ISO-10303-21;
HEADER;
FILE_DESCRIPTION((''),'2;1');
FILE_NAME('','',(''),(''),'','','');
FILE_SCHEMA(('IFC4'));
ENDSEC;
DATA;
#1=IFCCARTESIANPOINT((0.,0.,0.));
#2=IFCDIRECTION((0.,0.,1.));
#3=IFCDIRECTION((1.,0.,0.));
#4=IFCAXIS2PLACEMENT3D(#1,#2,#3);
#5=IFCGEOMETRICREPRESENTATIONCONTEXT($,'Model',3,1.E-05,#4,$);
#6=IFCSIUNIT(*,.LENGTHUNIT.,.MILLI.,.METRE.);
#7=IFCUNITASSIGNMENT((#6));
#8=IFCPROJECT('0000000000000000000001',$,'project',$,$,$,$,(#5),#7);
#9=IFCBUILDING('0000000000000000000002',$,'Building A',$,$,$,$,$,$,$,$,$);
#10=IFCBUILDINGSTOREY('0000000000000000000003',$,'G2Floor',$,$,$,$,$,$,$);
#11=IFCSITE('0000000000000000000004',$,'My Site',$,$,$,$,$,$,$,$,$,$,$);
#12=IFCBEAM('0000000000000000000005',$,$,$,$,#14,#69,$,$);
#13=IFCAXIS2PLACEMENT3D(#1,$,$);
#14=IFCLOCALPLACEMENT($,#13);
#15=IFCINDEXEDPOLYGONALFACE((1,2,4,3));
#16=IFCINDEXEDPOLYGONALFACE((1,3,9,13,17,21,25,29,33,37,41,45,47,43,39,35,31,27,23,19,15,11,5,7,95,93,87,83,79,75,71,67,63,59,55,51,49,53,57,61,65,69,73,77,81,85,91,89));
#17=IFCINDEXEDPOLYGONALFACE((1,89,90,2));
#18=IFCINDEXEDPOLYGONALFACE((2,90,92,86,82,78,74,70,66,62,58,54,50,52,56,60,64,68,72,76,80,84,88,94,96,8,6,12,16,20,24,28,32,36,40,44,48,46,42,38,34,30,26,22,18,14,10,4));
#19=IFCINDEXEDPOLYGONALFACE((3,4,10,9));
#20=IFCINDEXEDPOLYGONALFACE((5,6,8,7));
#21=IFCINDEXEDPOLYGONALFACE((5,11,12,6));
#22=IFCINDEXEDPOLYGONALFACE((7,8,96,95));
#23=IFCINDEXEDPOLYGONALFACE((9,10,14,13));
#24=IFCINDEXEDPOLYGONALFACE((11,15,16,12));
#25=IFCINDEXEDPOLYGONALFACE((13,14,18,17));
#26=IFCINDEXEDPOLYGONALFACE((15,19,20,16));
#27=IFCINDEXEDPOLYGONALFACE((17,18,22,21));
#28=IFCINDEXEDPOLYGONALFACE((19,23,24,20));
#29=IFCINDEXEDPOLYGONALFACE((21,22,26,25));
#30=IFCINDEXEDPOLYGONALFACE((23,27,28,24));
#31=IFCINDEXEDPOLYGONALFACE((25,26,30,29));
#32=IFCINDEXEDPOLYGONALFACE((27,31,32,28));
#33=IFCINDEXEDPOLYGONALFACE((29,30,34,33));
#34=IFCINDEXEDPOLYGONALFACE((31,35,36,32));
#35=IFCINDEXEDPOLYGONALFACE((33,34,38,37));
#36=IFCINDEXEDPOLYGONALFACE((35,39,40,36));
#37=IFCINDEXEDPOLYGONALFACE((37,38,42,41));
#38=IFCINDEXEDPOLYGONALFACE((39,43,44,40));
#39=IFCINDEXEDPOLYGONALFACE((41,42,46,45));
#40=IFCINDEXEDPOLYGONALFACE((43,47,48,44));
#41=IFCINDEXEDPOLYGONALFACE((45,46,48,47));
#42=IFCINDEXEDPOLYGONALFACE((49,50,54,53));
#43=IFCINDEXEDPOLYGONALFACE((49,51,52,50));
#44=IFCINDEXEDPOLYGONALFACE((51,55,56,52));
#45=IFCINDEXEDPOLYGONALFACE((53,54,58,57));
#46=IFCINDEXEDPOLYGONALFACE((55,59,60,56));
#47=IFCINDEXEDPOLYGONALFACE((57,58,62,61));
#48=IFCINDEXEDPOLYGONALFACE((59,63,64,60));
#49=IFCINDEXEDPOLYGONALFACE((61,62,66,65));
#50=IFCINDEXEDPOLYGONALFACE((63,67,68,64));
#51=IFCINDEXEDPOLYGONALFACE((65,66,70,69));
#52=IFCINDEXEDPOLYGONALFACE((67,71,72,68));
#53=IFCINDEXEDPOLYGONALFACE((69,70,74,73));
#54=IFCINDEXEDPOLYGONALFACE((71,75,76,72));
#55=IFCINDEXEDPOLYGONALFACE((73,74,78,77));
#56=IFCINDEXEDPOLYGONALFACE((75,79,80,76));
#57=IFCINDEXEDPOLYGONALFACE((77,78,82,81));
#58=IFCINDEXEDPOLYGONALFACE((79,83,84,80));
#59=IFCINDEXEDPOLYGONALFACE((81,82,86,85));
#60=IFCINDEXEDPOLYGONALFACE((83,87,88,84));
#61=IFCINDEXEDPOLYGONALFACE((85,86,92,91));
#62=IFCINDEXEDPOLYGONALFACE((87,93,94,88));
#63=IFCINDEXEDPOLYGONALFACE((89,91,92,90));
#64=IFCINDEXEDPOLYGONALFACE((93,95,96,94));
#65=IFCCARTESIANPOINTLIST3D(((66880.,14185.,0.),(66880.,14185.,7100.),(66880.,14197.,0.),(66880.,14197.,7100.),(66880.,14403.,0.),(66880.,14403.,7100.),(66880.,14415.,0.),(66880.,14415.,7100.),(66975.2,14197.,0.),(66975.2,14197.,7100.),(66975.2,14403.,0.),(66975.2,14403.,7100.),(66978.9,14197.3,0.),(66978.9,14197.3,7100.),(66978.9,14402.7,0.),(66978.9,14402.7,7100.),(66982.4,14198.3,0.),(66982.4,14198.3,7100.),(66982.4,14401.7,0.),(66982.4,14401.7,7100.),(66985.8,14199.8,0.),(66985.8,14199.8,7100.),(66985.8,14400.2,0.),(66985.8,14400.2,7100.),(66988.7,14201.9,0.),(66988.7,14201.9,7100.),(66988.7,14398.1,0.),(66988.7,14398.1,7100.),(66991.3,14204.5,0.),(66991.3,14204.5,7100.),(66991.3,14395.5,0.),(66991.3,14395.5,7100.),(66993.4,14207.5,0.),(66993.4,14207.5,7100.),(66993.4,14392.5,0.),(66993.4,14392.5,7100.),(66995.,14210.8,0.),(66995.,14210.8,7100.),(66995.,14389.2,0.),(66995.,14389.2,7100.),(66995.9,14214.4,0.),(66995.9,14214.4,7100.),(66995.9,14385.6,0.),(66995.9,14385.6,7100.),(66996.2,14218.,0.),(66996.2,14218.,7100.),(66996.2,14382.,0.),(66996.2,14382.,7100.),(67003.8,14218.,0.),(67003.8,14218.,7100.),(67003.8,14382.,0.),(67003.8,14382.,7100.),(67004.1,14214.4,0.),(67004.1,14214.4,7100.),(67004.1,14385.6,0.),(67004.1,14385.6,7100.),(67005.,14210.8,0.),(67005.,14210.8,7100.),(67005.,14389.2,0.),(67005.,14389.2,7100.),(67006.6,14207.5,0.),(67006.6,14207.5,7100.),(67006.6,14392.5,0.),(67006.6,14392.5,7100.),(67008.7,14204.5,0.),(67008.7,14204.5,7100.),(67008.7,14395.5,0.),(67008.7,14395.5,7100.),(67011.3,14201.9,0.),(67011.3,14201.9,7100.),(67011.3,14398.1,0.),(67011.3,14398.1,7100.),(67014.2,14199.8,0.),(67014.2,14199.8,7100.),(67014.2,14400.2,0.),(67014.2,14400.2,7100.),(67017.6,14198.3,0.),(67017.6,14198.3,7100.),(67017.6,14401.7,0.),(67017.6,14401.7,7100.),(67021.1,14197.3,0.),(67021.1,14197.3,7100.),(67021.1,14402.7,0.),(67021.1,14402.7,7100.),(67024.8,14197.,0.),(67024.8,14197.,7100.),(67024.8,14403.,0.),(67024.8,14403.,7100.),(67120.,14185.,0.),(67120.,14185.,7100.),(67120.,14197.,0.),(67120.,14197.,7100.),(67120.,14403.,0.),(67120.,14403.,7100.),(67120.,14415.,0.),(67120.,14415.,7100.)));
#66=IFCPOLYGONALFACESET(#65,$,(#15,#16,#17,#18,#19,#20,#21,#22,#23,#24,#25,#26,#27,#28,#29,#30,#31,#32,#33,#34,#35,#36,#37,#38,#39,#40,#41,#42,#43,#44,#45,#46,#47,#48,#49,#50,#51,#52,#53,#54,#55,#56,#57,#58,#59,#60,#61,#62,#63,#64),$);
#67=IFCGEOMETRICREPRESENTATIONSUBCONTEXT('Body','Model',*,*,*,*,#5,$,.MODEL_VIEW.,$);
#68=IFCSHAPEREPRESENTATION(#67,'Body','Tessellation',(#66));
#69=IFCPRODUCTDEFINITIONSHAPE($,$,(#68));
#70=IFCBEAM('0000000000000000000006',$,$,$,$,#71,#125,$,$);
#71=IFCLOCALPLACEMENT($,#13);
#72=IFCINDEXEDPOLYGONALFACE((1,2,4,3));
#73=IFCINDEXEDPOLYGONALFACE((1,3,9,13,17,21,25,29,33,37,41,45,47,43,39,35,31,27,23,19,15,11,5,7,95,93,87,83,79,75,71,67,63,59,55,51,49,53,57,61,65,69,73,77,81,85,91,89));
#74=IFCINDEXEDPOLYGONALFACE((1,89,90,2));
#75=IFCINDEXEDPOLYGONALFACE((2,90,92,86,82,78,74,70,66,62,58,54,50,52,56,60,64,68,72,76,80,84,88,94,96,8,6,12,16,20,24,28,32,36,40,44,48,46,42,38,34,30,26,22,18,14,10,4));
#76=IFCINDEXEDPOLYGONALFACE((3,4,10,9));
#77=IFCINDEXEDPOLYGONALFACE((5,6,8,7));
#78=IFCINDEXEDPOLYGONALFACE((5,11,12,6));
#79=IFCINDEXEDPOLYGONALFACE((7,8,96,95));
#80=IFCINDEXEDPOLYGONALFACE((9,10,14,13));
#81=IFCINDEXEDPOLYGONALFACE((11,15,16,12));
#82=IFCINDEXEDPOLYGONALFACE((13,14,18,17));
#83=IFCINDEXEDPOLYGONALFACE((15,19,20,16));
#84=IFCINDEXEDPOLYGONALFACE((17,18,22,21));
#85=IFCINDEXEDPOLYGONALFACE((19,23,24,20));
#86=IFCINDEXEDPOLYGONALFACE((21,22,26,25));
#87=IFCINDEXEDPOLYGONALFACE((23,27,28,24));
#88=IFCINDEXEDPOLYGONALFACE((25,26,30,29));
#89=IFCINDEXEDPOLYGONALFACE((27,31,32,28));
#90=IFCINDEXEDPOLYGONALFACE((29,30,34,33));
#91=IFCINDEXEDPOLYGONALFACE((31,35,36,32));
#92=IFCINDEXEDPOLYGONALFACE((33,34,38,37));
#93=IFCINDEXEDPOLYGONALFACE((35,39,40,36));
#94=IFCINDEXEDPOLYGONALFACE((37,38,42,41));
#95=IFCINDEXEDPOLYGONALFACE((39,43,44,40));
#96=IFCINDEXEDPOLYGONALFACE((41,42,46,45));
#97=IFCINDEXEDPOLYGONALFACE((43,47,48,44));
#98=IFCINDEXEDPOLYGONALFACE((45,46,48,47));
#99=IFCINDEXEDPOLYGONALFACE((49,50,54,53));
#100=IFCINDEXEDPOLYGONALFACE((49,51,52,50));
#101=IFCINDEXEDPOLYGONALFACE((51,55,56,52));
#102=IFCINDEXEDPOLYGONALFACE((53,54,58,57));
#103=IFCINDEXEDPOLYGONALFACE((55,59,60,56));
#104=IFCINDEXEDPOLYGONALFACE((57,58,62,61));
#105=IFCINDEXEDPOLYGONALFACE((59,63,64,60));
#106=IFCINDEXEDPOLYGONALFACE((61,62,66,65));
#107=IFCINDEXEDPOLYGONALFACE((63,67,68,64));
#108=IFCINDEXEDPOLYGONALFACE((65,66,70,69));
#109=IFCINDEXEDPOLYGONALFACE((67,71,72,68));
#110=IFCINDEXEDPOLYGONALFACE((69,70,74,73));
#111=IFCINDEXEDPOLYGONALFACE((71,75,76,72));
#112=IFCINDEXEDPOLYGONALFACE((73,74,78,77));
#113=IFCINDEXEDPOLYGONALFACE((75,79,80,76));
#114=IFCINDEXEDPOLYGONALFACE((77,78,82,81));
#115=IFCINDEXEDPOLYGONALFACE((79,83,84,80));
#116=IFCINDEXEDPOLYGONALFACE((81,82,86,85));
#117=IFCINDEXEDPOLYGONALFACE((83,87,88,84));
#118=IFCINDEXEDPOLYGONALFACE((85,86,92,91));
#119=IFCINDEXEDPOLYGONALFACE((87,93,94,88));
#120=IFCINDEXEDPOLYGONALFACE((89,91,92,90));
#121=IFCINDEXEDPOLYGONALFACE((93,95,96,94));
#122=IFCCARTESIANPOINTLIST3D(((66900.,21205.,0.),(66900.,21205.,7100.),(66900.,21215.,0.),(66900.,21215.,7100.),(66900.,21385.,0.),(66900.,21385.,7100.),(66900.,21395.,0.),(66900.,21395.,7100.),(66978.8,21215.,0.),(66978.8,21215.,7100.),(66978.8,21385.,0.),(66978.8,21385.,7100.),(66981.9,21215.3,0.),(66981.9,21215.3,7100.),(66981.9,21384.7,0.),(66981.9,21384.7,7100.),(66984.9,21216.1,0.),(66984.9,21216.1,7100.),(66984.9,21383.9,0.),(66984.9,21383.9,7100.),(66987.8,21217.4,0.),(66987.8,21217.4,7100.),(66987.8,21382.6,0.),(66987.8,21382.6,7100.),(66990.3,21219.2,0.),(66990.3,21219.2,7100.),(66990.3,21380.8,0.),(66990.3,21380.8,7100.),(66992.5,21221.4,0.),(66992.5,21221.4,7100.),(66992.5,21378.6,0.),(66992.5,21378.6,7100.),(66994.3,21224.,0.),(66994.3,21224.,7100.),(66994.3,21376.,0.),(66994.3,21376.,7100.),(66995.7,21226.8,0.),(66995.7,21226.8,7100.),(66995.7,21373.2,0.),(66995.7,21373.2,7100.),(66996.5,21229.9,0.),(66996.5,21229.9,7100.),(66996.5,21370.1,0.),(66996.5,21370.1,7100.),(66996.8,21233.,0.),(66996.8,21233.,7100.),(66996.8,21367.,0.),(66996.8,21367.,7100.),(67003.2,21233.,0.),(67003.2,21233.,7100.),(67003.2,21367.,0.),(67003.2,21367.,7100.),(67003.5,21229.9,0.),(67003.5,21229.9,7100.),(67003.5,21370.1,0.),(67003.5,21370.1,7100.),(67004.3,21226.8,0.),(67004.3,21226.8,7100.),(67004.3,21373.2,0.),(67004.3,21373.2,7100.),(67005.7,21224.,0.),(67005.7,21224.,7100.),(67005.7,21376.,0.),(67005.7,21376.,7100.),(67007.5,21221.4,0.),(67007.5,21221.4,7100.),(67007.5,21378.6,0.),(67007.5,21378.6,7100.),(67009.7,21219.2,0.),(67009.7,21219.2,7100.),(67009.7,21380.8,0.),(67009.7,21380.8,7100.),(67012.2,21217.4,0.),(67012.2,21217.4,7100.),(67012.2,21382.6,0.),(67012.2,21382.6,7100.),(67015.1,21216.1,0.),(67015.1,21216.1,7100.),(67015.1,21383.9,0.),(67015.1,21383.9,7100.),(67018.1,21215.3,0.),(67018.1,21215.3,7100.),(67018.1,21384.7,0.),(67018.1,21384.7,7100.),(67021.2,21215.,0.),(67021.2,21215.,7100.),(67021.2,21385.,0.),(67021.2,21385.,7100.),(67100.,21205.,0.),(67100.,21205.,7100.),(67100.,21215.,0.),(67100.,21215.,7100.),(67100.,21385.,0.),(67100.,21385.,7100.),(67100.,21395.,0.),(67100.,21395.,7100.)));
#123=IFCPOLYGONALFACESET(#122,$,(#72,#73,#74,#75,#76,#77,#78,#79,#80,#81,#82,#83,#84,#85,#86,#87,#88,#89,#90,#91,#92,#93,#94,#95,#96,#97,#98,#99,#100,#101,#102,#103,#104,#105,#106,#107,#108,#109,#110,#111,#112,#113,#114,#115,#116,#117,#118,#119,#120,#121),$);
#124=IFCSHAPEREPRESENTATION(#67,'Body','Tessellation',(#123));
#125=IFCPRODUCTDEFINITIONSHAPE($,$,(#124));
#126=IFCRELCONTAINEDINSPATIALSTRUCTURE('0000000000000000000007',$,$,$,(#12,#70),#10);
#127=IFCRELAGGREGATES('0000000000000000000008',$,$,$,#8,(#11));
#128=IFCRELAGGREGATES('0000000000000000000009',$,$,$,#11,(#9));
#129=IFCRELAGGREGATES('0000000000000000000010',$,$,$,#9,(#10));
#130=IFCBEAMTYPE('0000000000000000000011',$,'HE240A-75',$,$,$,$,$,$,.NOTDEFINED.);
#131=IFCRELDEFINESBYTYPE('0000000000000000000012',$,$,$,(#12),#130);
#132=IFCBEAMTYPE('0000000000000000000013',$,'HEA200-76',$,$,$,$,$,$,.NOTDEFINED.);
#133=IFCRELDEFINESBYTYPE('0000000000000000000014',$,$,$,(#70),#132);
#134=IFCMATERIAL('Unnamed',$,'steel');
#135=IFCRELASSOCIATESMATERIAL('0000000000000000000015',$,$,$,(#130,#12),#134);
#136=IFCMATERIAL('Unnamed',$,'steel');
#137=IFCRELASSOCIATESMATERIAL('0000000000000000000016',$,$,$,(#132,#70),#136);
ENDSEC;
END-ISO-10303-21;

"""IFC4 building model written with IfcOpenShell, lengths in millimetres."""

from ifc_helpers import new_model, si_unit, frame, origin_with_axes, place, context, subcontext, project, spatial, polyline, outline, extrude, material, material_profile, profile_set, profile_usage, type_object, element, save


model = new_model("IFC4")

# Units and contexts
model_context = context("Model", 3, precision=1e-05, world=origin_with_axes())
body_context = subcontext(model_context, "Body", "Model", "MODEL_VIEW")
ifc_project = project(units=[si_unit("LENGTHUNIT", "METRE", prefix="MILLI")], contexts=[model_context])

# Site, building, storey
site = spatial("IfcSite", under=ifc_project, Name="My Site")
building = spatial("IfcBuilding", under=site, Name="Building A")
storey = spatial("IfcBuildingStorey", under=building, Name="G2Floor")

# Beams
ifc_material_1 = material(Name="Unnamed", Category="steel")
ifc_material_profile_1 = material_profile(ifc_material_1, outline(polyline([(120.0, -115.0), (120.0, -103.0), (120.0, -103.0), (24.8, -103.0), (24.8, -103.0), (21.1, -102.7), (21.1, -102.7), (17.6, -101.7), (17.6, -101.7), (14.2, -100.2), (14.2, -100.2), (11.3, -98.1), (11.3, -98.1), (8.7, -95.5), (8.7, -95.5), (6.6, -92.5), (6.6, -92.5), (5.0, -89.2), (5.0, -89.2), (4.1, -85.6), (4.1, -85.6), (3.8, -82.0), (3.8, -82.0), (3.8, 82.0), (3.8, 82.0), (4.1, 85.6), (4.1, 85.6), (5.0, 89.2), (5.0, 89.2), (6.6, 92.5), (6.6, 92.5), (8.7, 95.5), (8.7, 95.5), (11.3, 98.1), (11.3, 98.1), (14.2, 100.2), (14.2, 100.2), (17.6, 101.7), (17.6, 101.7), (21.1, 102.7), (21.1, 102.7), (24.8, 103.0), (24.8, 103.0), (120.0, 103.0), (120.0, 103.0), (120.0, 115.0), (120.0, 115.0), (-120.0, 115.0), (-120.0, 115.0), (-120.0, 103.0), (-120.0, 103.0), (-24.8, 103.0), (-24.8, 103.0), (-21.1, 102.7), (-21.1, 102.7), (-17.6, 101.7), (-17.6, 101.7), (-14.2, 100.2), (-14.2, 100.2), (-11.3, 98.1), (-11.3, 98.1), (-8.7, 95.5), (-8.7, 95.5), (-6.6, 92.5), (-6.6, 92.5), (-5.0, 89.2), (-5.0, 89.2), (-4.1, 85.6), (-4.1, 85.6), (-3.8, 82.0), (-3.8, 82.0), (-3.8, -82.0), (-3.8, -82.0), (-4.1, -85.6), (-4.1, -85.6), (-5.0, -89.2), (-5.0, -89.2), (-6.6, -92.5), (-6.6, -92.5), (-8.7, -95.5), (-8.7, -95.5), (-11.3, -98.1), (-11.3, -98.1), (-14.2, -100.2), (-14.2, -100.2), (-17.6, -101.7), (-17.6, -101.7), (-21.1, -102.7), (-21.1, -102.7), (-24.8, -103.0), (-24.8, -103.0), (-120.0, -103.0), (-120.0, -103.0), (-120.0, -115.0), (-120.0, -115.0), (120.0, -115.0)])))
ifc_profile_set_1 = profile_set([ifc_material_profile_1], Name="HE240A-75")
ifc_profile_usage_1 = profile_usage(ifc_profile_set_1)
beam_type_1 = type_object("IfcBeamType", Name="HE240A-75", PredefinedType="NOTDEFINED", material=ifc_profile_set_1)
beam_1_placement = place(None, frame((67000.0, 14300.0, 0.0), z_axis=(0.0, 0.0, 1.0), x_axis=(1.0, 0.0, 0.0)))
element("IfcBeam", 1, at=beam_1_placement, inside=storey, type_object=beam_type_1, material=ifc_profile_usage_1, context=body_context, shape_type="SweptSolid", body=[
    extrude(outline(polyline([(120.0, -115.0), (120.0, -103.0), (120.0, -103.0), (24.8, -103.0), (24.8, -103.0), (21.1, -102.7), (21.1, -102.7), (17.6, -101.7), (17.6, -101.7), (14.2, -100.2), (14.2, -100.2), (11.3, -98.1), (11.3, -98.1), (8.7, -95.5), (8.7, -95.5), (6.6, -92.5), (6.6, -92.5), (5.0, -89.2), (5.0, -89.2), (4.1, -85.6), (4.1, -85.6), (3.8, -82.0), (3.8, -82.0), (3.8, 82.0), (3.8, 82.0), (4.1, 85.6), (4.1, 85.6), (5.0, 89.2), (5.0, 89.2), (6.6, 92.5), (6.6, 92.5), (8.7, 95.5), (8.7, 95.5), (11.3, 98.1), (11.3, 98.1), (14.2, 100.2), (14.2, 100.2), (17.6, 101.7), (17.6, 101.7), (21.1, 102.7), (21.1, 102.7), (24.8, 103.0), (24.8, 103.0), (120.0, 103.0), (120.0, 103.0), (120.0, 115.0), (120.0, 115.0), (-120.0, 115.0), (-120.0, 115.0), (-120.0, 103.0), (-120.0, 103.0), (-24.8, 103.0), (-24.8, 103.0), (-21.1, 102.7), (-21.1, 102.7), (-17.6, 101.7), (-17.6, 101.7), (-14.2, 100.2), (-14.2, 100.2), (-11.3, 98.1), (-11.3, 98.1), (-8.7, 95.5), (-8.7, 95.5), (-6.6, 92.5), (-6.6, 92.5), (-5.0, 89.2), (-5.0, 89.2), (-4.1, 85.6), (-4.1, 85.6), (-3.8, 82.0), (-3.8, 82.0), (-3.8, -82.0), (-3.8, -82.0), (-4.1, -85.6), (-4.1, -85.6), (-5.0, -89.2), (-5.0, -89.2), (-6.6, -92.5), (-6.6, -92.5), (-8.7, -95.5), (-8.7, -95.5), (-11.3, -98.1), (-11.3, -98.1), (-14.2, -100.2), (-14.2, -100.2), (-17.6, -101.7), (-17.6, -101.7), (-21.1, -102.7), (-21.1, -102.7), (-24.8, -103.0), (-24.8, -103.0), (-120.0, -103.0), (-120.0, -103.0), (-120.0, -115.0), (-120.0, -115.0), (120.0, -115.0)])), origin_with_axes(), (0.0, 0.0, 1.0), 7100.0),
])
ifc_material_2 = material(Name="Unnamed", Category="steel")
ifc_material_profile_2 = material_profile(ifc_material_2, outline(polyline([(100.0, -95.0), (100.0, -85.0), (100.0, -85.0), (21.2, -85.0), (21.2, -85.0), (18.1, -84.7), (18.1, -84.7), (15.1, -83.9), (15.1, -83.9), (12.2, -82.6), (12.2, -82.6), (9.7, -80.8), (9.7, -80.8), (7.5, -78.6), (7.5, -78.6), (5.7, -76.0), (5.7, -76.0), (4.3, -73.2), (4.3, -73.2), (3.5, -70.1), (3.5, -70.1), (3.2, -67.0), (3.2, -67.0), (3.2, 67.0), (3.2, 67.0), (3.5, 70.1), (3.5, 70.1), (4.3, 73.2), (4.3, 73.2), (5.7, 76.0), (5.7, 76.0), (7.5, 78.6), (7.5, 78.6), (9.7, 80.8), (9.7, 80.8), (12.2, 82.6), (12.2, 82.6), (15.1, 83.9), (15.1, 83.9), (18.1, 84.7), (18.1, 84.7), (21.2, 85.0), (21.2, 85.0), (100.0, 85.0), (100.0, 85.0), (100.0, 95.0), (100.0, 95.0), (-100.0, 95.0), (-100.0, 95.0), (-100.0, 85.0), (-100.0, 85.0), (-21.2, 85.0), (-21.2, 85.0), (-18.1, 84.7), (-18.1, 84.7), (-15.1, 83.9), (-15.1, 83.9), (-12.2, 82.6), (-12.2, 82.6), (-9.7, 80.8), (-9.7, 80.8), (-7.5, 78.6), (-7.5, 78.6), (-5.7, 76.0), (-5.7, 76.0), (-4.3, 73.2), (-4.3, 73.2), (-3.5, 70.1), (-3.5, 70.1), (-3.2, 67.0), (-3.2, 67.0), (-3.2, -67.0), (-3.2, -67.0), (-3.5, -70.1), (-3.5, -70.1), (-4.3, -73.2), (-4.3, -73.2), (-5.7, -76.0), (-5.7, -76.0), (-7.5, -78.6), (-7.5, -78.6), (-9.7, -80.8), (-9.7, -80.8), (-12.2, -82.6), (-12.2, -82.6), (-15.1, -83.9), (-15.1, -83.9), (-18.1, -84.7), (-18.1, -84.7), (-21.2, -85.0), (-21.2, -85.0), (-100.0, -85.0), (-100.0, -85.0), (-100.0, -95.0), (-100.0, -95.0), (100.0, -95.0)])))
ifc_profile_set_2 = profile_set([ifc_material_profile_2], Name="HEA200-76")
ifc_profile_usage_2 = profile_usage(ifc_profile_set_2)
beam_type_2 = type_object("IfcBeamType", Name="HEA200-76", PredefinedType="NOTDEFINED", material=ifc_profile_set_2)
beam_2_placement = place(None, frame((67000.0, 21300.0, 0.0), z_axis=(0.0, 0.0, 1.0), x_axis=(1.0, 0.0, 0.0)))
element("IfcBeam", 2, at=beam_2_placement, inside=storey, type_object=beam_type_2, material=ifc_profile_usage_2, context=body_context, shape_type="SweptSolid", body=[
    extrude(outline(polyline([(100.0, -95.0), (100.0, -85.0), (100.0, -85.0), (21.2, -85.0), (21.2, -85.0), (18.1, -84.7), (18.1, -84.7), (15.1, -83.9), (15.1, -83.9), (12.2, -82.6), (12.2, -82.6), (9.7, -80.8), (9.7, -80.8), (7.5, -78.6), (7.5, -78.6), (5.7, -76.0), (5.7, -76.0), (4.3, -73.2), (4.3, -73.2), (3.5, -70.1), (3.5, -70.1), (3.2, -67.0), (3.2, -67.0), (3.2, 67.0), (3.2, 67.0), (3.5, 70.1), (3.5, 70.1), (4.3, 73.2), (4.3, 73.2), (5.7, 76.0), (5.7, 76.0), (7.5, 78.6), (7.5, 78.6), (9.7, 80.8), (9.7, 80.8), (12.2, 82.6), (12.2, 82.6), (15.1, 83.9), (15.1, 83.9), (18.1, 84.7), (18.1, 84.7), (21.2, 85.0), (21.2, 85.0), (100.0, 85.0), (100.0, 85.0), (100.0, 95.0), (100.0, 95.0), (-100.0, 95.0), (-100.0, 95.0), (-100.0, 85.0), (-100.0, 85.0), (-21.2, 85.0), (-21.2, 85.0), (-18.1, 84.7), (-18.1, 84.7), (-15.1, 83.9), (-15.1, 83.9), (-12.2, 82.6), (-12.2, 82.6), (-9.7, 80.8), (-9.7, 80.8), (-7.5, 78.6), (-7.5, 78.6), (-5.7, 76.0), (-5.7, 76.0), (-4.3, 73.2), (-4.3, 73.2), (-3.5, 70.1), (-3.5, 70.1), (-3.2, 67.0), (-3.2, 67.0), (-3.2, -67.0), (-3.2, -67.0), (-3.5, -70.1), (-3.5, -70.1), (-4.3, -73.2), (-4.3, -73.2), (-5.7, -76.0), (-5.7, -76.0), (-7.5, -78.6), (-7.5, -78.6), (-9.7, -80.8), (-9.7, -80.8), (-12.2, -82.6), (-12.2, -82.6), (-15.1, -83.9), (-15.1, -83.9), (-18.1, -84.7), (-18.1, -84.7), (-21.2, -85.0), (-21.2, -85.0), (-100.0, -85.0), (-100.0, -85.0), (-100.0, -95.0), (-100.0, -95.0), (100.0, -95.0)])), origin_with_axes(), (0.0, 0.0, 1.0), 7100.0),
])

save(model, "model.ifc")
